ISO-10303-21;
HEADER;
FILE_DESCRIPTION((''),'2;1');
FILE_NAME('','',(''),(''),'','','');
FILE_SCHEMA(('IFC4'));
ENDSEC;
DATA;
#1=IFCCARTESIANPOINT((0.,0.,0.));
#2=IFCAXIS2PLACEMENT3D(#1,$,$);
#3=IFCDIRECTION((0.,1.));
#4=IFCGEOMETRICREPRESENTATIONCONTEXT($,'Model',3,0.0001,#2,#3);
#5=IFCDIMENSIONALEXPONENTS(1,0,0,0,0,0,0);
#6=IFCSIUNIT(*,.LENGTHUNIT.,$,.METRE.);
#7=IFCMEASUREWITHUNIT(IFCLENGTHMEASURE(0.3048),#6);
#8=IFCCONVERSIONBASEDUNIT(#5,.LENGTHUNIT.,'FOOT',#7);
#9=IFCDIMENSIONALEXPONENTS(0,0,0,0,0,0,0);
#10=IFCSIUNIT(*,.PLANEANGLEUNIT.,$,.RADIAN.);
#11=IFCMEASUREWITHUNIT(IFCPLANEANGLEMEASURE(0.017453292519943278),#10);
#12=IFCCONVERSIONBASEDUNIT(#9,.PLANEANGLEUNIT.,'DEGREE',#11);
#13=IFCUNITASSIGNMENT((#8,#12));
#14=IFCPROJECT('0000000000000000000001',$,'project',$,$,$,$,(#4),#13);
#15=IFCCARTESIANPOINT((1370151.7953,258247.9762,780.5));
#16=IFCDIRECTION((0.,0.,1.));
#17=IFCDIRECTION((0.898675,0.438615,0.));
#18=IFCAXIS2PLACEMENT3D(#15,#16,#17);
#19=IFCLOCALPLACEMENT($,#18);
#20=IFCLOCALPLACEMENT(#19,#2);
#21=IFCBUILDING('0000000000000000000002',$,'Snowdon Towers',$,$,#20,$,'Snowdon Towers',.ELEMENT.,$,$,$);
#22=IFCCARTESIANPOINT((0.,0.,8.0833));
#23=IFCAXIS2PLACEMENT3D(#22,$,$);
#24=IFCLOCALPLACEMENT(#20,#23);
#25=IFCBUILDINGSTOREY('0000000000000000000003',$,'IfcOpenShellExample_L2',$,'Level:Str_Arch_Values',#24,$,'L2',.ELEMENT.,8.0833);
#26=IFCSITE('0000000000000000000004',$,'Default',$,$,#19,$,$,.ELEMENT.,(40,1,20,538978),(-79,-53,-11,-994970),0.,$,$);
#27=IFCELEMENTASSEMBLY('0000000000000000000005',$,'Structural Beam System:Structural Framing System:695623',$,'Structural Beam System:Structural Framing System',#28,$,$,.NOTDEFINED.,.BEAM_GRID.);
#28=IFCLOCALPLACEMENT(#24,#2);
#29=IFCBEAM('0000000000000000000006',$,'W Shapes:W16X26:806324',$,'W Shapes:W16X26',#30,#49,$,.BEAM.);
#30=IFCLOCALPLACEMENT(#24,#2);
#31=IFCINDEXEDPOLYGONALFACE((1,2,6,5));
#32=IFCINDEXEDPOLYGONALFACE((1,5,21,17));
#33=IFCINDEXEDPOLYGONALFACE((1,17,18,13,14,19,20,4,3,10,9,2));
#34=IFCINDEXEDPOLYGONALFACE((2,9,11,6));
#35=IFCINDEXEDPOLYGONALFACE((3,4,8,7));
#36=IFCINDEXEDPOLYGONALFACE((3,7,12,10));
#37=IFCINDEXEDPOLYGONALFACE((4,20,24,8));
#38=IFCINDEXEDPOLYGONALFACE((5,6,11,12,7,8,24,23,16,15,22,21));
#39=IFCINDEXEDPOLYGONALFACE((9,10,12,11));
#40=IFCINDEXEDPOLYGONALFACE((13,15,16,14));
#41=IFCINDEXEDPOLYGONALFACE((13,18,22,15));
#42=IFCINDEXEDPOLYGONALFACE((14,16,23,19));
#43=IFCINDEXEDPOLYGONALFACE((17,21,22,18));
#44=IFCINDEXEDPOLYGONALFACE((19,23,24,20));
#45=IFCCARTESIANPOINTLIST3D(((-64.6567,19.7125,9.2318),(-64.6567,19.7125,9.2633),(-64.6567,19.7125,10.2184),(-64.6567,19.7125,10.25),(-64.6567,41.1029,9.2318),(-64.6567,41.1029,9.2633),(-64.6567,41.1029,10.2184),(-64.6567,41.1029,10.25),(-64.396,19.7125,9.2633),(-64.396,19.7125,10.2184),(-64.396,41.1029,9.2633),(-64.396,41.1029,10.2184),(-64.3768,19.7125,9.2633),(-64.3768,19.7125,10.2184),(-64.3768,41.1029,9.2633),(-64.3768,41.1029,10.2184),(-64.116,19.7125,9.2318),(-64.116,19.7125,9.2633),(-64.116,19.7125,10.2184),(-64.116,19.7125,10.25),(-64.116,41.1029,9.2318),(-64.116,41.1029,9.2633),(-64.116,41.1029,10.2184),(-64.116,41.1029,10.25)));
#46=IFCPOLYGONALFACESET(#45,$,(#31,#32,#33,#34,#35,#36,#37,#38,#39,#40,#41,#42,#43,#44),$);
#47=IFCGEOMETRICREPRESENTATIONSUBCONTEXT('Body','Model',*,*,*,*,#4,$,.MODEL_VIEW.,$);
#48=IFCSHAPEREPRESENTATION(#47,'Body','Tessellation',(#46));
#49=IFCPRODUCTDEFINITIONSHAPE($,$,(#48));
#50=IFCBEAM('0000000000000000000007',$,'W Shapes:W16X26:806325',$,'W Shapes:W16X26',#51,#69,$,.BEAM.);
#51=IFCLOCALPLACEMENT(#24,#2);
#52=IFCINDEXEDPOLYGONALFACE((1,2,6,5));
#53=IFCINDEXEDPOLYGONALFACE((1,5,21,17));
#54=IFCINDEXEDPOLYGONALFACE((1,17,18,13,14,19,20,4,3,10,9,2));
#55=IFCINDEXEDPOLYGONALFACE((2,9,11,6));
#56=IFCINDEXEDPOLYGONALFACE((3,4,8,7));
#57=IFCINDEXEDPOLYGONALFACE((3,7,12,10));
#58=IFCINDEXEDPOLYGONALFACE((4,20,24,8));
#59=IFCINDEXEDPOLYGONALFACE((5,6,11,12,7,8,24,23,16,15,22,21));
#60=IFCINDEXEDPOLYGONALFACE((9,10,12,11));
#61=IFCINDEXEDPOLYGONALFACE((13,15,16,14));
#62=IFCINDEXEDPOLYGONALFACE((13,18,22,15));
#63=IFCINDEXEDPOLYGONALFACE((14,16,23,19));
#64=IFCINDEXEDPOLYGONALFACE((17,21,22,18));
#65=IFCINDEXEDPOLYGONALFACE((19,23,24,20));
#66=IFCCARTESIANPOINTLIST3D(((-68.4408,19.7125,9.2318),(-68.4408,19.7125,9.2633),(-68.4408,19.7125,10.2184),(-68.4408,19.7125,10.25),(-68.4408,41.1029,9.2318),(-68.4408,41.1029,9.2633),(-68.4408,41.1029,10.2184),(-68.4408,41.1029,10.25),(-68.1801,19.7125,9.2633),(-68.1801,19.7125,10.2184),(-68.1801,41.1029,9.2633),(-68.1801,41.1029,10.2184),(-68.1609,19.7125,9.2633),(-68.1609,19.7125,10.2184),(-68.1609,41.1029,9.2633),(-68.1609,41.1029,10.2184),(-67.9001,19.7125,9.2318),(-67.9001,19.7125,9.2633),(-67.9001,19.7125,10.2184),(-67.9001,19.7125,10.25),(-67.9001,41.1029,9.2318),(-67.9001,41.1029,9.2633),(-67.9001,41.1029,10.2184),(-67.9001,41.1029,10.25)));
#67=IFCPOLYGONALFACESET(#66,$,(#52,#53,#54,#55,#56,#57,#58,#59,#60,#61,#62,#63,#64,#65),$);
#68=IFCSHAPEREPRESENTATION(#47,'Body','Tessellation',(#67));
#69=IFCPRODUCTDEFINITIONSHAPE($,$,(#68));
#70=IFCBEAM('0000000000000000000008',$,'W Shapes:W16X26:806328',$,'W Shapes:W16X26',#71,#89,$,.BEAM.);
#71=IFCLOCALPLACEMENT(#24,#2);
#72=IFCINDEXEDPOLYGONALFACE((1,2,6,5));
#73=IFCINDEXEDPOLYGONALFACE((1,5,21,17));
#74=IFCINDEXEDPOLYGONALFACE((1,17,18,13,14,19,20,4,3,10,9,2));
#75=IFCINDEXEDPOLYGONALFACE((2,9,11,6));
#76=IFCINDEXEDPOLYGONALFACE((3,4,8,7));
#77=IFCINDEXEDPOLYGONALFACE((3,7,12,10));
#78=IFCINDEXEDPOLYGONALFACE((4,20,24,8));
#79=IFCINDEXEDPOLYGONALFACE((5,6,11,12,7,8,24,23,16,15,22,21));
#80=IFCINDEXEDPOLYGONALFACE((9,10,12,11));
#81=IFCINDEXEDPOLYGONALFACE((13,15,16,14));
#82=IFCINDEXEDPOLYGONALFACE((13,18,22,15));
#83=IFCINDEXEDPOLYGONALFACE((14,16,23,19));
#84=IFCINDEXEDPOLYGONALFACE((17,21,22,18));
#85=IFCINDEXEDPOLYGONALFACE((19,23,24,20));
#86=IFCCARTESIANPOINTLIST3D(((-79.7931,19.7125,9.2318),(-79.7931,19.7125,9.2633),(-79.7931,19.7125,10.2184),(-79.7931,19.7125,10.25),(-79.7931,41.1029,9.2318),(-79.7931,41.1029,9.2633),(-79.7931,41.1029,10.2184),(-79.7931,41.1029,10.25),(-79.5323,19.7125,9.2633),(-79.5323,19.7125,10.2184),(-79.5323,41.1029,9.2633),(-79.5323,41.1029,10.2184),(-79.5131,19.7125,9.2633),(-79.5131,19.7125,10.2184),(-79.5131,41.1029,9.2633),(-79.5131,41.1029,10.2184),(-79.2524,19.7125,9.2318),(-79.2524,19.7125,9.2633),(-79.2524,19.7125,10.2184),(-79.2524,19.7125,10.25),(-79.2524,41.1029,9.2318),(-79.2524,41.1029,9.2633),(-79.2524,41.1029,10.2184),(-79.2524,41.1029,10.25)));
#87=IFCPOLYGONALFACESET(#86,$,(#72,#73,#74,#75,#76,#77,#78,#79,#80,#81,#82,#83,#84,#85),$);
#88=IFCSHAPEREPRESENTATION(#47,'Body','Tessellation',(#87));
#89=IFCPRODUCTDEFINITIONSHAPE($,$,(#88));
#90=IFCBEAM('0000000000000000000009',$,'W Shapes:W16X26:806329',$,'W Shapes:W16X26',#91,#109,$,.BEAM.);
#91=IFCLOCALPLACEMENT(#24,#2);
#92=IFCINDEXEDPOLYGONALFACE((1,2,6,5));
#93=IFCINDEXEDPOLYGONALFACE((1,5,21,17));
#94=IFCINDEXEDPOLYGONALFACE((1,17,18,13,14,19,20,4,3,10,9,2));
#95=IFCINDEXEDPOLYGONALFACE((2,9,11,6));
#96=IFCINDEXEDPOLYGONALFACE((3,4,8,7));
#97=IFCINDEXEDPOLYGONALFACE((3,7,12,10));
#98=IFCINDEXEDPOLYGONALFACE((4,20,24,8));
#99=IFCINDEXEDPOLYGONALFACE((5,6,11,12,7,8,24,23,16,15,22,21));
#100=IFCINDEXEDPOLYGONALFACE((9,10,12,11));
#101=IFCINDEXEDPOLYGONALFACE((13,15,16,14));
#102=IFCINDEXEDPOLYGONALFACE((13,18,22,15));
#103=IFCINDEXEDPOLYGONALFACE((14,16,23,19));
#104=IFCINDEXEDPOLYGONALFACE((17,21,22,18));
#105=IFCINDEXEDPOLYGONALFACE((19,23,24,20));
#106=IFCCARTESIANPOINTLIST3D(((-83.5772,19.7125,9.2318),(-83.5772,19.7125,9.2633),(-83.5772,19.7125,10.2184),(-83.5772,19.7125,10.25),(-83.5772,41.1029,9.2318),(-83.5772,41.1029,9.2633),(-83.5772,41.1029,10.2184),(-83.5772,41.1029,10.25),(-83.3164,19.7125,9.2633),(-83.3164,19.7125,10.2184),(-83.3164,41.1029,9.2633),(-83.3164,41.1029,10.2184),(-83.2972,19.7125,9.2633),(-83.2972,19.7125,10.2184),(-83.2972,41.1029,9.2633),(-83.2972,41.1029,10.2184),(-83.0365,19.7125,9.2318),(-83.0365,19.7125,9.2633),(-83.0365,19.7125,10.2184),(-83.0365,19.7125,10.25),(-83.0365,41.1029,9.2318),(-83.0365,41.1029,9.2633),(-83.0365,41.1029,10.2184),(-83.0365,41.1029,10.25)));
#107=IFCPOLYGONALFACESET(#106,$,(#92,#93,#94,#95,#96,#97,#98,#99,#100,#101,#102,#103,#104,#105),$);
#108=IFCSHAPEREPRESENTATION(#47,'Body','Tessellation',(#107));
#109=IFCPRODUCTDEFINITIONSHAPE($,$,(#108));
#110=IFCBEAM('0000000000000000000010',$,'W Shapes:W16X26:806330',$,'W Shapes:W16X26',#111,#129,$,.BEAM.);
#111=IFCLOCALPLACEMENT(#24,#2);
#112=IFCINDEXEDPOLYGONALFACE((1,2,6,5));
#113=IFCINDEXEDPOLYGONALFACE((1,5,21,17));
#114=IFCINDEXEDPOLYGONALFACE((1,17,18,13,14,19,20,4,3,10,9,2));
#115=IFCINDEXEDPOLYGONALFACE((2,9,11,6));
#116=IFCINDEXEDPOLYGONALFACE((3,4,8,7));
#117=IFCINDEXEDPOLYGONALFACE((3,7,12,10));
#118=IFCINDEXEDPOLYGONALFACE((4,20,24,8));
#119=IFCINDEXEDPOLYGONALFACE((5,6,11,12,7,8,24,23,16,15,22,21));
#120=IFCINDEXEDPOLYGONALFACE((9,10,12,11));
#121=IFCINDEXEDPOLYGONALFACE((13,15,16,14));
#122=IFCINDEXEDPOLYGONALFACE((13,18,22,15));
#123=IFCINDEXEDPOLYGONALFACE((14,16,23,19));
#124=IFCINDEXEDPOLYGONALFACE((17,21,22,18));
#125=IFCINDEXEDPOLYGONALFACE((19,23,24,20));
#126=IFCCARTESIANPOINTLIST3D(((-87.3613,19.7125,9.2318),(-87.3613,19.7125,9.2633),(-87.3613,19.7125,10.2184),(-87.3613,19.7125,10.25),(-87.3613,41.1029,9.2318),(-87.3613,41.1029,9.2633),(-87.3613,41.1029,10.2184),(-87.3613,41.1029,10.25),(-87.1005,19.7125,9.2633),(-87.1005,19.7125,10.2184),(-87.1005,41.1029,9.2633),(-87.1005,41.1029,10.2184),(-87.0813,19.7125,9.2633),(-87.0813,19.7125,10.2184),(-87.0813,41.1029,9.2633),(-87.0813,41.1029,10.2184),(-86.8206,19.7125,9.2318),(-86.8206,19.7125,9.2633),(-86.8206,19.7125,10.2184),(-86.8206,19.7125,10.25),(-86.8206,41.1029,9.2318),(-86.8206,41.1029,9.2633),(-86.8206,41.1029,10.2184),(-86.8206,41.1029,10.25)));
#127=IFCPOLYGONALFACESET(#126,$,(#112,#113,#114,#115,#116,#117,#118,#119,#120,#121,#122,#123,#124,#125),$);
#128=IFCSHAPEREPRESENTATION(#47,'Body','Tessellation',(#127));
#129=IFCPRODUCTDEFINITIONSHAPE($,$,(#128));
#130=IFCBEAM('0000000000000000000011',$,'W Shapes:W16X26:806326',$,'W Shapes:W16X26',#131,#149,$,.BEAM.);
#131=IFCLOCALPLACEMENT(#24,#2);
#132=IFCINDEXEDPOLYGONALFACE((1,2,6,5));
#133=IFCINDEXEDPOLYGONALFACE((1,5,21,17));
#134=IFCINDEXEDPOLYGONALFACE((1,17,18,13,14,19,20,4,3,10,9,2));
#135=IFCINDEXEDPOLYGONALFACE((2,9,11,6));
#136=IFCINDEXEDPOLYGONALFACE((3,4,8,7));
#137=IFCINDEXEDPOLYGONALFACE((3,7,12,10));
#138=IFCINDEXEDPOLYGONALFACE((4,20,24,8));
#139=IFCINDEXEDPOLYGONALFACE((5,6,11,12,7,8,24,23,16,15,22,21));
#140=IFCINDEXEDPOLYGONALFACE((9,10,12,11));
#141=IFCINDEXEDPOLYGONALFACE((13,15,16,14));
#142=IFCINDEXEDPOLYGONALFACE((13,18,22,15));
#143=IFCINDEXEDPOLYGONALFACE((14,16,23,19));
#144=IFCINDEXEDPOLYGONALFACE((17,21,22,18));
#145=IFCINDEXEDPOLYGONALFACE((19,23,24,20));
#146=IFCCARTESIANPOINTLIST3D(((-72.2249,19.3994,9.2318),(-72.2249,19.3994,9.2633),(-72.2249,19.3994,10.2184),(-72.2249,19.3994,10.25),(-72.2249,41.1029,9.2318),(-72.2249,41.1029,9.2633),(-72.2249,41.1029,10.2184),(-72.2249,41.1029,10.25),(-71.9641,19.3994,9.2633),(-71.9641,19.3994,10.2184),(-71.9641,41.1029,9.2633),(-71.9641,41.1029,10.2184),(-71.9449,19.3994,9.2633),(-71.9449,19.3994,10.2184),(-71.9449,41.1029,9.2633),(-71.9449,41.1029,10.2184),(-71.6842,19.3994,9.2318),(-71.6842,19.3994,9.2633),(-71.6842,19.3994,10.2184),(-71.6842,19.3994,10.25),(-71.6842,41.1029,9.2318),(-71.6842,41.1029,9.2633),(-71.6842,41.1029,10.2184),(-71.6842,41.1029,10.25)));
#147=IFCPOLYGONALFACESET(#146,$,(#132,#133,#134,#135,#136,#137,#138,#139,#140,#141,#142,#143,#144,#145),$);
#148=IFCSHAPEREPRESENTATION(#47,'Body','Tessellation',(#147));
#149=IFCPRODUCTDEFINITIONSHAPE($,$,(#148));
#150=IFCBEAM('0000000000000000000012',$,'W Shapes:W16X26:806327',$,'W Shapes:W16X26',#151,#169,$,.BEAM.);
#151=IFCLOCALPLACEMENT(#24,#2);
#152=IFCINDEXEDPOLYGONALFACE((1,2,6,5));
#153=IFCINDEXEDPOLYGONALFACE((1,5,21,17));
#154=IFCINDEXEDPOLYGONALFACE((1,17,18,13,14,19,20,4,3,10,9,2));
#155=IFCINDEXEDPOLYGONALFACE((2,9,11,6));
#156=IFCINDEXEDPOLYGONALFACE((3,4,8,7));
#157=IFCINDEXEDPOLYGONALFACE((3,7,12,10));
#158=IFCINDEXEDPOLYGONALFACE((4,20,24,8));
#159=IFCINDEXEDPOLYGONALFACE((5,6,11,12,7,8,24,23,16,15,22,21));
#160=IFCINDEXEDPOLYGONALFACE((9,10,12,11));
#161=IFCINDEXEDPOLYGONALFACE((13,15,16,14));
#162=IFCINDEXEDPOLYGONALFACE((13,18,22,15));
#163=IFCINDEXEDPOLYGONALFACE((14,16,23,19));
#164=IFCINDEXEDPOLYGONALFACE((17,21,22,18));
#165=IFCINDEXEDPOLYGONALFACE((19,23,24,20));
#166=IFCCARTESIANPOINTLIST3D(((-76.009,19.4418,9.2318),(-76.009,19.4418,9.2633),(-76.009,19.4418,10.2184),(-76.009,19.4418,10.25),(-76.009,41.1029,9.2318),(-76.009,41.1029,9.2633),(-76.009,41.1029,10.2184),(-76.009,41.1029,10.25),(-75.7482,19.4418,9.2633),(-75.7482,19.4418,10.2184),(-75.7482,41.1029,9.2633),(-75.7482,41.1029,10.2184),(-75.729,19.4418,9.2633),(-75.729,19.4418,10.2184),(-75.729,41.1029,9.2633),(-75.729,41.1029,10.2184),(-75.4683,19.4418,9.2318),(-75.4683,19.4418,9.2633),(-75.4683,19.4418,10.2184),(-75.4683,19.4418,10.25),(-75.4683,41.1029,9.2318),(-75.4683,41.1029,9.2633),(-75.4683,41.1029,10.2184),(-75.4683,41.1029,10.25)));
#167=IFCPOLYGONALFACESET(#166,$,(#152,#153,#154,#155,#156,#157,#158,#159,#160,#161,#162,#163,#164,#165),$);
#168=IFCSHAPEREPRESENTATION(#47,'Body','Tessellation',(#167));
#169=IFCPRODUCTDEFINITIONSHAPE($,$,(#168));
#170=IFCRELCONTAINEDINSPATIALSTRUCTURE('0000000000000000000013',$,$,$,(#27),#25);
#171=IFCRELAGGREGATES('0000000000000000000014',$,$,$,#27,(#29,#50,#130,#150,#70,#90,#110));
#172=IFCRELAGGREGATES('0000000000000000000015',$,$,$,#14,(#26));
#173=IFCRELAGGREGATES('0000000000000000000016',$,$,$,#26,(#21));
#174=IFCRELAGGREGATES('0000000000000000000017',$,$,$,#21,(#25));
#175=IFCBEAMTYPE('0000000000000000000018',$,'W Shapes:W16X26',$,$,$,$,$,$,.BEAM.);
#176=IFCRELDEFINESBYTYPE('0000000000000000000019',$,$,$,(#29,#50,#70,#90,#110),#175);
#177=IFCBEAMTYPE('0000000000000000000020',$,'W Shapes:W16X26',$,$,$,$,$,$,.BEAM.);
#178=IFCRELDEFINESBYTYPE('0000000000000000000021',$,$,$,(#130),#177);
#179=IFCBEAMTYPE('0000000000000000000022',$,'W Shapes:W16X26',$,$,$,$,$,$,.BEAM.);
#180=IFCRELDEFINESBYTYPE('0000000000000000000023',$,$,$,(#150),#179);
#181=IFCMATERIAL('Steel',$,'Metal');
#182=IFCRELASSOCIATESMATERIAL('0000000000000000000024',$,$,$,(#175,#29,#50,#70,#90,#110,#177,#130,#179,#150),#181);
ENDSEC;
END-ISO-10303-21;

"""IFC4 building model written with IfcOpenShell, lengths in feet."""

from ifc_helpers import new_model, entity, si_unit, converted_unit, direction, frame, origin, place, context, subcontext, project, spatial, indexed_curve, outline, extrude, source, transform, mapped, material, type_object, type_shapes, element, aggregate, save


model = new_model("IFC4")

# Units and contexts
model_context = context("Model", 3, precision=0.0001, world=origin(), true_north=direction((0.0, 1.0)))
body_context = subcontext(model_context, "Body", "Model", "MODEL_VIEW")
ifc_project = project(units=[converted_unit("LENGTHUNIT", "FOOT", entity("IfcLengthMeasure", 0.3048), si_unit("LENGTHUNIT", "METRE"), dimensions=[1, 0, 0, 0, 0, 0, 0]), converted_unit("PLANEANGLEUNIT", "DEGREE", entity("IfcPlaneAngleMeasure", 0.017453292519943278), si_unit("PLANEANGLEUNIT", "RADIAN"), dimensions=[0, 0, 0, 0, 0, 0, 0])], contexts=[model_context])

# Site, building, storey
site_placement = place(None, frame((1370151.7953, 258247.9762, 780.5), z_axis=(0.0, 0.0, 1.0), x_axis=(0.898675, 0.438615, 0.0)))
site = spatial("IfcSite", under=ifc_project, at=site_placement, Name="Default", CompositionType="ELEMENT", RefLatitude=(40, 1, 20, 538978), RefLongitude=(-79, -53, -11, -994970), RefElevation=0.0)
building_placement = place(site_placement, origin())
building = spatial("IfcBuilding", under=site, at=building_placement, Name="Snowdon Towers", LongName="Snowdon Towers", CompositionType="ELEMENT")
storey_placement = place(building_placement, frame((0.0, 0.0, 8.0833)))
storey = spatial("IfcBuildingStorey", under=building, at=storey_placement, Name="IfcOpenShellExample_L2", ObjectType="Level:Str_Arch_Values", LongName="L2", CompositionType="ELEMENT", Elevation=8.0833)

# Shared definitions
ifc_material = material(Name="Steel", Category="Metal")

# Element assembly, beams
assembly_1_placement = place(storey_placement, origin())
assembly_1 = element("IfcElementAssembly", 1, at=assembly_1_placement, inside=storey, Name="Structural Beam System:Structural Framing System:695623", ObjectType="Structural Beam System:Structural Framing System", AssemblyPlace="NOTDEFINED", PredefinedType="BEAM_GRID")
beam_type_1 = type_object("IfcBeamType", Name="W Shapes:W16X26", PredefinedType="BEAM", material=ifc_material)
shared_shape_1 = source(origin(), body_context, "Body", "SweptSolid", [
    extrude(outline(indexed_curve([(-0.2703, -0.4775), (-0.2703, -0.5091), (0.2703, -0.5091), (0.2703, -0.4775), (0.0096, -0.4775), (0.0096, 0.4775), (0.2703, 0.4775), (0.2703, 0.5091), (-0.2703, 0.5091), (-0.2703, 0.4775), (-0.0096, 0.4775), (-0.0096, -0.4775), (-0.2703, -0.4775)], self_intersect=False)), frame((-10.7696, 0.0, 0.0), z_axis=(-1.0, 0.0, 0.0), x_axis=(0.0, -1.0, 0.0)), (0.0, 0.0, -1.0), 21.3904),
])
type_shapes(beam_type_1, [shared_shape_1])
beam_1_placement = place(assembly_1_placement, frame((-64.3864, 30.3333, 9.7409), z_axis=(0.0, 0.0, 1.0), x_axis=(0.0, -1.0, 0.0)))
beam_1 = element("IfcBeam", 2, at=beam_1_placement, type_object=beam_type_1, material=ifc_material, Name="W Shapes:W16X26:806324", ObjectType="W Shapes:W16X26", PredefinedType="BEAM", context=body_context, shape_type="MappedRepresentation", body=[
    mapped(shared_shape_1, transform((0.0, 0.0, 0.0), scale=1.0)),
])
beam_2_placement = place(assembly_1_placement, frame((-68.1705, 30.3333, 9.7409), z_axis=(0.0, 0.0, 1.0), x_axis=(0.0, -1.0, 0.0)))
beam_2 = element("IfcBeam", 3, at=beam_2_placement, type_object=beam_type_1, material=ifc_material, Name="W Shapes:W16X26:806325", ObjectType="W Shapes:W16X26", PredefinedType="BEAM", context=body_context, shape_type="MappedRepresentation", body=[
    mapped(shared_shape_1, transform((0.0, 0.0, 0.0), scale=1.0)),
])
beam_3_placement = place(assembly_1_placement, frame((-79.5227, 30.3333, 9.7409), z_axis=(0.0, 0.0, 1.0), x_axis=(0.0, -1.0, 0.0)))
beam_3 = element("IfcBeam", 4, at=beam_3_placement, type_object=beam_type_1, material=ifc_material, Name="W Shapes:W16X26:806328", ObjectType="W Shapes:W16X26", PredefinedType="BEAM", context=body_context, shape_type="MappedRepresentation", body=[
    mapped(shared_shape_1, transform((0.0, 0.0, 0.0), scale=1.0)),
])
beam_4_placement = place(assembly_1_placement, frame((-83.3068, 30.3333, 9.7409), z_axis=(0.0, 0.0, 1.0), x_axis=(0.0, -1.0, 0.0)))
beam_4 = element("IfcBeam", 5, at=beam_4_placement, type_object=beam_type_1, material=ifc_material, Name="W Shapes:W16X26:806329", ObjectType="W Shapes:W16X26", PredefinedType="BEAM", context=body_context, shape_type="MappedRepresentation", body=[
    mapped(shared_shape_1, transform((0.0, 0.0, 0.0), scale=1.0)),
])
beam_5_placement = place(assembly_1_placement, frame((-87.0909, 30.3333, 9.7409), z_axis=(0.0, 0.0, 1.0), x_axis=(0.0, -1.0, 0.0)))
beam_5 = element("IfcBeam", 6, at=beam_5_placement, type_object=beam_type_1, material=ifc_material, Name="W Shapes:W16X26:806330", ObjectType="W Shapes:W16X26", PredefinedType="BEAM", context=body_context, shape_type="MappedRepresentation", body=[
    mapped(shared_shape_1, transform((0.0, 0.0, 0.0), scale=1.0)),
])
beam_type_2 = type_object("IfcBeamType", Name="W Shapes:W16X26", PredefinedType="BEAM", material=ifc_material)
shared_shape_2 = source(origin(), body_context, "Body", "SweptSolid", [
    extrude(outline(indexed_curve([(-0.2703, -0.4775), (-0.2703, -0.5091), (0.2703, -0.5091), (0.2703, -0.4775), (0.0096, -0.4775), (0.0096, 0.4775), (0.2703, 0.4775), (0.2703, 0.5091), (-0.2703, 0.5091), (-0.2703, 0.4775), (-0.0096, 0.4775), (-0.0096, -0.4775), (-0.2703, -0.4775)], self_intersect=False)), frame((-10.7696, 0.0, 0.0), z_axis=(-1.0, 0.0, 0.0), x_axis=(0.0, -1.0, 0.0)), (0.0, 0.0, -1.0), 21.7035),
])
type_shapes(beam_type_2, [shared_shape_2])
beam_6_placement = place(assembly_1_placement, frame((-71.9545, 30.3333, 9.7409), z_axis=(0.0, 0.0, 1.0), x_axis=(0.0, -1.0, 0.0)))
beam_6 = element("IfcBeam", 7, at=beam_6_placement, type_object=beam_type_2, material=ifc_material, Name="W Shapes:W16X26:806326", ObjectType="W Shapes:W16X26", PredefinedType="BEAM", context=body_context, shape_type="MappedRepresentation", body=[
    mapped(shared_shape_2, transform((0.0, 0.0, 0.0), scale=1.0)),
])
beam_type_3 = type_object("IfcBeamType", Name="W Shapes:W16X26", PredefinedType="BEAM", material=ifc_material)
shared_shape_3 = source(origin(), body_context, "Body", "SweptSolid", [
    extrude(outline(indexed_curve([(-0.2703, -0.4775), (-0.2703, -0.5091), (0.2703, -0.5091), (0.2703, -0.4775), (0.0096, -0.4775), (0.0096, 0.4775), (0.2703, 0.4775), (0.2703, 0.5091), (-0.2703, 0.5091), (-0.2703, 0.4775), (-0.0096, 0.4775), (-0.0096, -0.4775), (-0.2703, -0.4775)], self_intersect=False)), frame((-10.7696, 0.0, 0.0), z_axis=(-1.0, 0.0, 0.0), x_axis=(0.0, -1.0, 0.0)), (0.0, 0.0, -1.0), 21.6611),
])
type_shapes(beam_type_3, [shared_shape_3])
beam_7_placement = place(assembly_1_placement, frame((-75.7386, 30.3333, 9.7409), z_axis=(0.0, 0.0, 1.0), x_axis=(0.0, -1.0, 0.0)))
beam_7 = element("IfcBeam", 8, at=beam_7_placement, type_object=beam_type_3, material=ifc_material, Name="W Shapes:W16X26:806327", ObjectType="W Shapes:W16X26", PredefinedType="BEAM", context=body_context, shape_type="MappedRepresentation", body=[
    mapped(shared_shape_3, transform((0.0, 0.0, 0.0), scale=1.0)),
])
aggregate(assembly_1, [beam_1, beam_2, beam_6, beam_7, beam_3, beam_4, beam_5])

save(model, "model.ifc")
